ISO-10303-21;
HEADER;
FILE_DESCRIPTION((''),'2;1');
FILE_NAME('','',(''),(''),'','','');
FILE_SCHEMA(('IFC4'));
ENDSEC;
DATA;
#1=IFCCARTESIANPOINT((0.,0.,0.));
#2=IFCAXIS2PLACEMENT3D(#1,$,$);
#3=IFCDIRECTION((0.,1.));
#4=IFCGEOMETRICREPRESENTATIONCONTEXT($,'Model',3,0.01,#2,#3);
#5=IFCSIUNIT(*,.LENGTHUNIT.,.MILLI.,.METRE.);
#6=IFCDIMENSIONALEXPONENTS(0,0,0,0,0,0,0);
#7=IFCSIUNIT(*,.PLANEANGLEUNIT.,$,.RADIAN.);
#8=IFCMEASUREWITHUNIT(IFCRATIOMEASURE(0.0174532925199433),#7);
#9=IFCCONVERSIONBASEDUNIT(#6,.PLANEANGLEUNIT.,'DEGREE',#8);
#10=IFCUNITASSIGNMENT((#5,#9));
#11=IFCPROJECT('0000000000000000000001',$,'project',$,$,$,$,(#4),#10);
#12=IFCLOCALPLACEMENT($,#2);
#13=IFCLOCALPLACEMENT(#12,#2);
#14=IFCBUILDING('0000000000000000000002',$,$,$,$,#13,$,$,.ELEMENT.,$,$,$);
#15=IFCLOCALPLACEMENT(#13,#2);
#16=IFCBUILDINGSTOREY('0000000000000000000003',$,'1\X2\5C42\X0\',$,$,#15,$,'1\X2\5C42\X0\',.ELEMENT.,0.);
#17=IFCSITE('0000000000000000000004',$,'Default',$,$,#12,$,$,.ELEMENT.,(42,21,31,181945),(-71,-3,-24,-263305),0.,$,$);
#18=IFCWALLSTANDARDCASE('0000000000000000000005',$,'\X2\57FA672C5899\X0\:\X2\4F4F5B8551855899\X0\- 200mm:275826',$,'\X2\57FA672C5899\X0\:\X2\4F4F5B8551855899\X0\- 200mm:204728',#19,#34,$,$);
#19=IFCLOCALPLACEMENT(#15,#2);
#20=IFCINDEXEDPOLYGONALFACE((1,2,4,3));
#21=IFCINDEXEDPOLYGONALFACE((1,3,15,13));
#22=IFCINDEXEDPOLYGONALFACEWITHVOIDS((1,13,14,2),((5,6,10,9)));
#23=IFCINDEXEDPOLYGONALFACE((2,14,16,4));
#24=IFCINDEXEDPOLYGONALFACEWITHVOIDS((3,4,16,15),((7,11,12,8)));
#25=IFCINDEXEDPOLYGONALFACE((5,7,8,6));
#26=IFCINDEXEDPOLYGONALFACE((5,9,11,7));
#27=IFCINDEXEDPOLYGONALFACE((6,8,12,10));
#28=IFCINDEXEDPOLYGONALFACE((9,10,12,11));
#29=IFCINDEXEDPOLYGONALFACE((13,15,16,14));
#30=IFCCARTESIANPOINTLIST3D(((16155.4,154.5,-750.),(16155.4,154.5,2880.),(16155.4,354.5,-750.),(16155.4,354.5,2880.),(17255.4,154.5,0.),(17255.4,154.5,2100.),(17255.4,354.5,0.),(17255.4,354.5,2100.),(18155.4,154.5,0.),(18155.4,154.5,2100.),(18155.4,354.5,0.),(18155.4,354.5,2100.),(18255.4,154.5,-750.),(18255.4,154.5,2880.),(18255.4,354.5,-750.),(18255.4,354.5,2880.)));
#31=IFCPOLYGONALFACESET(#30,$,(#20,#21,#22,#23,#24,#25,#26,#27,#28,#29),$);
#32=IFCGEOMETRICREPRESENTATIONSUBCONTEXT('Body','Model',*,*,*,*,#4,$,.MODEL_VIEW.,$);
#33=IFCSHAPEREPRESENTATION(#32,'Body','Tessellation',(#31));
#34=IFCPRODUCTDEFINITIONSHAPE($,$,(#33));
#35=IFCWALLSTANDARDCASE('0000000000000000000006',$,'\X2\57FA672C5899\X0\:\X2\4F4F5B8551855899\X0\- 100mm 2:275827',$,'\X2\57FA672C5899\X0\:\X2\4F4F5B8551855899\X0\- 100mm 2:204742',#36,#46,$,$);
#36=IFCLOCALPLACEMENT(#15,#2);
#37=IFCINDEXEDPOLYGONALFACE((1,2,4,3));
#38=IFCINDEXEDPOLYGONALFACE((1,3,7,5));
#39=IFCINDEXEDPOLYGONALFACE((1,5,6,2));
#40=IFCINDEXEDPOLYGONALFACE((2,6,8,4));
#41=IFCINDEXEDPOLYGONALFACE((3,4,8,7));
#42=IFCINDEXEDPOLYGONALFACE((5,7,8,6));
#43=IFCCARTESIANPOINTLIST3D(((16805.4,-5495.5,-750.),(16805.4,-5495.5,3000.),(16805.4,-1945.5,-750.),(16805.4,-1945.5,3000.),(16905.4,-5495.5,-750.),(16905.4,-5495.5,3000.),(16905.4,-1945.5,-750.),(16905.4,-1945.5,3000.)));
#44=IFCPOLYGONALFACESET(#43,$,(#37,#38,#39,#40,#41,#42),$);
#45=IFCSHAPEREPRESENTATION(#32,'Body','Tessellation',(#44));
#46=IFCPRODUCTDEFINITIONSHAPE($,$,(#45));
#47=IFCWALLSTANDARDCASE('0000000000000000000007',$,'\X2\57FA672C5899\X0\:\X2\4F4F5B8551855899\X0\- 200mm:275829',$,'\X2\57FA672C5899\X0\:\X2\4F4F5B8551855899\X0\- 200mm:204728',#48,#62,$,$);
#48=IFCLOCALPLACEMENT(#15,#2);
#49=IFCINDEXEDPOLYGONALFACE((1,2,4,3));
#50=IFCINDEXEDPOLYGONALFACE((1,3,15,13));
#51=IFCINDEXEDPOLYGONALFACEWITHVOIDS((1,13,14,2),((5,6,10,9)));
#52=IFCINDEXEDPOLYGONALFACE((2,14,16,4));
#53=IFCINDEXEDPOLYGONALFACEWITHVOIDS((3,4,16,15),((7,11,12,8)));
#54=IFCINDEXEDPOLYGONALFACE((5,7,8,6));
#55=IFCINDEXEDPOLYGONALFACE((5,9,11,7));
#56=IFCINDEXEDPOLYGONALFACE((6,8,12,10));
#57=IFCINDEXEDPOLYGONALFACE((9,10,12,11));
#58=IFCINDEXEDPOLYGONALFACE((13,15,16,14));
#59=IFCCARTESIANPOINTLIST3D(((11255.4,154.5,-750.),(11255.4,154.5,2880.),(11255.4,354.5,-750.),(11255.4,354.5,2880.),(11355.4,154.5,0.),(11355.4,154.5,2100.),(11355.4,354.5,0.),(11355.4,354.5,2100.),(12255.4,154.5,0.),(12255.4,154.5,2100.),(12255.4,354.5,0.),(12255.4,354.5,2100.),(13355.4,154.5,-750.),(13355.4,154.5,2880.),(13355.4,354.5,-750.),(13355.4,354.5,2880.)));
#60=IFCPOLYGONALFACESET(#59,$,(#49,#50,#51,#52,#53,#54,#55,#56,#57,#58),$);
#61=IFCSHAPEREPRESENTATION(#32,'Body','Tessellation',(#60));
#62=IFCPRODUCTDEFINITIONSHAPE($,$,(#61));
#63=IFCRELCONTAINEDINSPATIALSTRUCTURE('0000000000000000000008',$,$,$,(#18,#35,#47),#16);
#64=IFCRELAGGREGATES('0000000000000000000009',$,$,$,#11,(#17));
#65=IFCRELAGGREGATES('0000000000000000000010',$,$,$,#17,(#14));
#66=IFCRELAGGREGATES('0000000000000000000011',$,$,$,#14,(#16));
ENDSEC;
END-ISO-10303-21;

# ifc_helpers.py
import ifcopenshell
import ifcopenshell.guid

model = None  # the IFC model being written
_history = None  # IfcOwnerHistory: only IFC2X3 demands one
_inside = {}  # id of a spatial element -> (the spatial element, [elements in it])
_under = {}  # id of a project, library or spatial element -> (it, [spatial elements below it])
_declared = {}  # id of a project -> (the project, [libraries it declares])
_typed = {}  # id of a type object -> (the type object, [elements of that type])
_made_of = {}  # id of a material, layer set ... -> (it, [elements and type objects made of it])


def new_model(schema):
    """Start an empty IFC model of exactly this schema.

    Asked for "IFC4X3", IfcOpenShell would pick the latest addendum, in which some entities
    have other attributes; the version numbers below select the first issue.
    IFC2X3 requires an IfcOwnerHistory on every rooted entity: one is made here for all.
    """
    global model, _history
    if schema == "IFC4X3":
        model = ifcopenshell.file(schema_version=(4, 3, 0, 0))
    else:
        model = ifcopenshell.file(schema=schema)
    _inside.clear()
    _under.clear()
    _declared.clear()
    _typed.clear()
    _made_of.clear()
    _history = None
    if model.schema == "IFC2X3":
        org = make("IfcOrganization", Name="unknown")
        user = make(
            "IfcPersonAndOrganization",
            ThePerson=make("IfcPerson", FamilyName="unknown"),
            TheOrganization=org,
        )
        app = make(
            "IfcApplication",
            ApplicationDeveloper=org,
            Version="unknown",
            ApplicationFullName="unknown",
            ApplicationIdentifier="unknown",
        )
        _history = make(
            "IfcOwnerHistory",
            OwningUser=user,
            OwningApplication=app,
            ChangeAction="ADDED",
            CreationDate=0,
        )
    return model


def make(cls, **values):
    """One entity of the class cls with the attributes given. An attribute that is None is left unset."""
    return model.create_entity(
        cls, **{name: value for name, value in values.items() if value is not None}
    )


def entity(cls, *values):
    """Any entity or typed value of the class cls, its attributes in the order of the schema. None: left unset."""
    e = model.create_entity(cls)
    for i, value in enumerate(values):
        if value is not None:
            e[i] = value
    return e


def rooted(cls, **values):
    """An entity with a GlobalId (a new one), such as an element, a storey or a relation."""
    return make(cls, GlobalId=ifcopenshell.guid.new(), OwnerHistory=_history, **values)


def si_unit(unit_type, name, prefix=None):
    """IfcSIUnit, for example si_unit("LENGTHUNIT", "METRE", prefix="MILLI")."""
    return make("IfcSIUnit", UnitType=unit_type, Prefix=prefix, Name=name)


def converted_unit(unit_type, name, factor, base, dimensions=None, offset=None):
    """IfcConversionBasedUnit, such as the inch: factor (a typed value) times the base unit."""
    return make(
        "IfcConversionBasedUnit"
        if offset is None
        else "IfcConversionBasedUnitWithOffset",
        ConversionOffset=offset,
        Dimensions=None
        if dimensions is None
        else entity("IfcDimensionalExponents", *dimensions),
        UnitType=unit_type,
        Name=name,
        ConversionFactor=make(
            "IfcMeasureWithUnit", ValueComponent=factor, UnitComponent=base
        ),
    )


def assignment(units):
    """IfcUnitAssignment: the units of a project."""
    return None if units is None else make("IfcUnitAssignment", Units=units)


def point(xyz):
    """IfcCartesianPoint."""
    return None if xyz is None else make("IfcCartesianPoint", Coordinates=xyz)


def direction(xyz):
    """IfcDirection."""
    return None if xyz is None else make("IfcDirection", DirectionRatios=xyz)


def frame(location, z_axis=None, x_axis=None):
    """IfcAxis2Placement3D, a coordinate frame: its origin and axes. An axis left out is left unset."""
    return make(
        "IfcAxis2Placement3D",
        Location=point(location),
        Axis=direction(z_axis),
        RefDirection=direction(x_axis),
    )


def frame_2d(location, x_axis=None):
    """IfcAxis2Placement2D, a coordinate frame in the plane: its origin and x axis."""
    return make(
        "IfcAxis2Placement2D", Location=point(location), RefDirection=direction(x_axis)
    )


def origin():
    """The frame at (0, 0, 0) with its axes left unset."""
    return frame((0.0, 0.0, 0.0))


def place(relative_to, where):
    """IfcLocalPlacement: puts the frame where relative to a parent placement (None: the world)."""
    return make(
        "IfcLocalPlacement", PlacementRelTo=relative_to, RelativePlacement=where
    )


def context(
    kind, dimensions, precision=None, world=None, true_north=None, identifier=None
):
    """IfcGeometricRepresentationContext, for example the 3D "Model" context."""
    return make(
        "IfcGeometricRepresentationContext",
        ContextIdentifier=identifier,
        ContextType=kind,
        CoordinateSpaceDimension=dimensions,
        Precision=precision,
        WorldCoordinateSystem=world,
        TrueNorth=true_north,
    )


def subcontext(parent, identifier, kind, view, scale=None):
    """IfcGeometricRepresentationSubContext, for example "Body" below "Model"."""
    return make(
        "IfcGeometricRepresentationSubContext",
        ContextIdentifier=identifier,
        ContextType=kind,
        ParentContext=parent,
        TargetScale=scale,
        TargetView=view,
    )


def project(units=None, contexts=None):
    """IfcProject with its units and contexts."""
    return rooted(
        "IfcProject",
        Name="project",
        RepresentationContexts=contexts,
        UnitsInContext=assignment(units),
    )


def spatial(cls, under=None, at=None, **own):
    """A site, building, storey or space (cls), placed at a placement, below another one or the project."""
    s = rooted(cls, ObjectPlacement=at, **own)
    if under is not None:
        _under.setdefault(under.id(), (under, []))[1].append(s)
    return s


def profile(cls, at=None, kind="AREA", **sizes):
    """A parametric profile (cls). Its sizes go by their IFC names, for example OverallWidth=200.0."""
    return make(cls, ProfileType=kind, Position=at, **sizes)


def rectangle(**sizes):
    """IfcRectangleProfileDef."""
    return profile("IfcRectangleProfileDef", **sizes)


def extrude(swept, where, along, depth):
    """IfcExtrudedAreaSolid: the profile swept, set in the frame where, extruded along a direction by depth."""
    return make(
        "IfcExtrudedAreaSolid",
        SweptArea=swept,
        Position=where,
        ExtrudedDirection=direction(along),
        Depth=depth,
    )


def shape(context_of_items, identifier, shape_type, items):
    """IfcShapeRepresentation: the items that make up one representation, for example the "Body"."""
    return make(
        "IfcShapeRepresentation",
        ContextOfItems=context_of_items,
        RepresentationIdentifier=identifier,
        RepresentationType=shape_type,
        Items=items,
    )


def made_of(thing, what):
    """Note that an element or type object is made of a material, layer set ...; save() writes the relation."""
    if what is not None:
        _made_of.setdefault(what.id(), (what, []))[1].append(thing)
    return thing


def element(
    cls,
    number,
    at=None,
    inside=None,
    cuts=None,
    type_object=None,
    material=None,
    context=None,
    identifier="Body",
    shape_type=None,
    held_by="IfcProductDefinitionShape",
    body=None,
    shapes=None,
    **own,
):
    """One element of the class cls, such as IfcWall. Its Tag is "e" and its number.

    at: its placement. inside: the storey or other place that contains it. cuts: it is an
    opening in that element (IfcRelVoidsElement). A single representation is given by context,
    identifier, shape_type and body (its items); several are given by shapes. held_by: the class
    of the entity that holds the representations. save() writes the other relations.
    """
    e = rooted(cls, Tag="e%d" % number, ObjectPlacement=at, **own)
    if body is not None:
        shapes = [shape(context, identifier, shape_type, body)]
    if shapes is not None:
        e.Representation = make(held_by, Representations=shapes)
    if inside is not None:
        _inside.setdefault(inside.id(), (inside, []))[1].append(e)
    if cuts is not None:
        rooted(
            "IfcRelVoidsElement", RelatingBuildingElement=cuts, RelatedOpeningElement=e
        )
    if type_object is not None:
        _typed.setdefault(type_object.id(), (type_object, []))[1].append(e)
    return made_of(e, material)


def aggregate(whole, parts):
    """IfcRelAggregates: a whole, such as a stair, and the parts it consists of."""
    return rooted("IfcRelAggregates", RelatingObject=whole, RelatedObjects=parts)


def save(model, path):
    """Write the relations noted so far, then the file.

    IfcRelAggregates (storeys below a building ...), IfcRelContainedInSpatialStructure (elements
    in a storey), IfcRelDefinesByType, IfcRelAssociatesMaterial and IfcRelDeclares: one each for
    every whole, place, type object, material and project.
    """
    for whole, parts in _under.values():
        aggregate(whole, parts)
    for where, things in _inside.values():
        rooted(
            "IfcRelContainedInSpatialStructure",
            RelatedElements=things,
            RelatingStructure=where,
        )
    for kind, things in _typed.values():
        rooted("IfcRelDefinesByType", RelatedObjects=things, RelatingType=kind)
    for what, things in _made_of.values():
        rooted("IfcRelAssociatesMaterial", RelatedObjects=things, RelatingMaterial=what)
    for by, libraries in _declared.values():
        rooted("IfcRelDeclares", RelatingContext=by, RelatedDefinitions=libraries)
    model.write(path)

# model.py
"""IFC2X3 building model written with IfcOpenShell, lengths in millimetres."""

from ifc_helpers import new_model, entity, si_unit, converted_unit, direction, frame, frame_2d, origin, place, context, subcontext, project, spatial, rectangle, extrude, element, save


model = new_model("IFC2X3")

# Units and contexts
model_context = context("Model", 3, precision=0.01, world=origin(), true_north=direction((0.0, 1.0)))
body_context = subcontext(model_context, "Body", "Model", "MODEL_VIEW")
ifc_project = project(units=[si_unit("LENGTHUNIT", "METRE", prefix="MILLI"), converted_unit("PLANEANGLEUNIT", "DEGREE", entity("IfcRatioMeasure", 0.0174532925199433), si_unit("PLANEANGLEUNIT", "RADIAN"), dimensions=[0, 0, 0, 0, 0, 0, 0])], contexts=[model_context])

# Site, building, storey
site_placement = place(None, origin())
site = spatial("IfcSite", under=ifc_project, at=site_placement, Name="Default", CompositionType="ELEMENT", RefLatitude=(42, 21, 31, 181945), RefLongitude=(-71, -3, -24, -263305), RefElevation=0.0)
building_placement = place(site_placement, origin())
building = spatial("IfcBuilding", under=site, at=building_placement, CompositionType="ELEMENT")
storey_placement = place(building_placement, origin())
storey = spatial("IfcBuildingStorey", under=building, at=storey_placement, Name="1层", LongName="1层", CompositionType="ELEMENT", Elevation=0.0)

# Wall, opening
wall_1_placement = place(storey_placement, frame((18255.4, 254.5, -750.0), z_axis=(0.0, 0.0, 1.0), x_axis=(-1.0, 0.0, 0.0)))
wall_1 = element("IfcWallStandardCase", 1, at=wall_1_placement, inside=storey, Name="基本墙:住宅内墙- 200mm:275826", ObjectType="基本墙:住宅内墙- 200mm:204728", context=body_context, shape_type="SweptSolid", body=[
    extrude(rectangle(XDim=2100.0, YDim=200.0, at=frame_2d((1050.0, 0.0), x_axis=(-1.0, 0.0))), origin(), (0.0, 0.0, 1.0), 3630.0),
])
opening_1_placement = place(wall_1_placement, frame((1000.0, 100.0, 750.0)))
element("IfcOpeningElement", 2, at=opening_1_placement, cuts=wall_1, ObjectType="Opening", context=body_context, shape_type="SweptSolid", body=[
    extrude(rectangle(XDim=2100.0, YDim=900.0, at=frame_2d((1050.0, 450.0), x_axis=(1.0, 0.0))), frame((0.0, 0.0, 0.0), z_axis=(0.0, -1.0, 0.0), x_axis=(0.0, 0.0, 1.0)), (0.0, 0.0, 1.0), 200.0),
])

# Wall
wall_2_placement = place(storey_placement, frame((16855.4, -1945.5, -750.0), z_axis=(0.0, 0.0, 1.0), x_axis=(0.0, -1.0, 0.0)))
element("IfcWallStandardCase", 3, at=wall_2_placement, inside=storey, Name="基本墙:住宅内墙- 100mm 2:275827", ObjectType="基本墙:住宅内墙- 100mm 2:204742", context=body_context, shape_type="SweptSolid", body=[
    extrude(rectangle(XDim=3550.0, YDim=100.0, at=frame_2d((1775.0, 0.0), x_axis=(-1.0, 0.0))), origin(), (0.0, 0.0, 1.0), 3750.0),
])

# Wall, opening
wall_3_placement = place(storey_placement, frame((11255.4, 254.5, -750.0)))
wall_3 = element("IfcWallStandardCase", 4, at=wall_3_placement, inside=storey, Name="基本墙:住宅内墙- 200mm:275829", ObjectType="基本墙:住宅内墙- 200mm:204728", context=body_context, shape_type="SweptSolid", body=[
    extrude(rectangle(XDim=2100.0, YDim=200.0, at=frame_2d((1050.0, 0.0), x_axis=(-1.0, 0.0))), origin(), (0.0, 0.0, 1.0), 3630.0),
])
opening_2_placement = place(wall_3_placement, frame((100.0, -100.0, 750.0)))
element("IfcOpeningElement", 5, at=opening_2_placement, cuts=wall_3, ObjectType="Opening", context=body_context, shape_type="SweptSolid", body=[
    extrude(rectangle(XDim=2100.0, YDim=900.0, at=frame_2d((1050.0, 450.0), x_axis=(1.0, 0.0))), frame((0.0, 0.0, 0.0), z_axis=(0.0, 1.0, 0.0), x_axis=(0.0, 0.0, 1.0)), (0.0, 0.0, 1.0), 200.0),
])

save(model, "model.ifc")
